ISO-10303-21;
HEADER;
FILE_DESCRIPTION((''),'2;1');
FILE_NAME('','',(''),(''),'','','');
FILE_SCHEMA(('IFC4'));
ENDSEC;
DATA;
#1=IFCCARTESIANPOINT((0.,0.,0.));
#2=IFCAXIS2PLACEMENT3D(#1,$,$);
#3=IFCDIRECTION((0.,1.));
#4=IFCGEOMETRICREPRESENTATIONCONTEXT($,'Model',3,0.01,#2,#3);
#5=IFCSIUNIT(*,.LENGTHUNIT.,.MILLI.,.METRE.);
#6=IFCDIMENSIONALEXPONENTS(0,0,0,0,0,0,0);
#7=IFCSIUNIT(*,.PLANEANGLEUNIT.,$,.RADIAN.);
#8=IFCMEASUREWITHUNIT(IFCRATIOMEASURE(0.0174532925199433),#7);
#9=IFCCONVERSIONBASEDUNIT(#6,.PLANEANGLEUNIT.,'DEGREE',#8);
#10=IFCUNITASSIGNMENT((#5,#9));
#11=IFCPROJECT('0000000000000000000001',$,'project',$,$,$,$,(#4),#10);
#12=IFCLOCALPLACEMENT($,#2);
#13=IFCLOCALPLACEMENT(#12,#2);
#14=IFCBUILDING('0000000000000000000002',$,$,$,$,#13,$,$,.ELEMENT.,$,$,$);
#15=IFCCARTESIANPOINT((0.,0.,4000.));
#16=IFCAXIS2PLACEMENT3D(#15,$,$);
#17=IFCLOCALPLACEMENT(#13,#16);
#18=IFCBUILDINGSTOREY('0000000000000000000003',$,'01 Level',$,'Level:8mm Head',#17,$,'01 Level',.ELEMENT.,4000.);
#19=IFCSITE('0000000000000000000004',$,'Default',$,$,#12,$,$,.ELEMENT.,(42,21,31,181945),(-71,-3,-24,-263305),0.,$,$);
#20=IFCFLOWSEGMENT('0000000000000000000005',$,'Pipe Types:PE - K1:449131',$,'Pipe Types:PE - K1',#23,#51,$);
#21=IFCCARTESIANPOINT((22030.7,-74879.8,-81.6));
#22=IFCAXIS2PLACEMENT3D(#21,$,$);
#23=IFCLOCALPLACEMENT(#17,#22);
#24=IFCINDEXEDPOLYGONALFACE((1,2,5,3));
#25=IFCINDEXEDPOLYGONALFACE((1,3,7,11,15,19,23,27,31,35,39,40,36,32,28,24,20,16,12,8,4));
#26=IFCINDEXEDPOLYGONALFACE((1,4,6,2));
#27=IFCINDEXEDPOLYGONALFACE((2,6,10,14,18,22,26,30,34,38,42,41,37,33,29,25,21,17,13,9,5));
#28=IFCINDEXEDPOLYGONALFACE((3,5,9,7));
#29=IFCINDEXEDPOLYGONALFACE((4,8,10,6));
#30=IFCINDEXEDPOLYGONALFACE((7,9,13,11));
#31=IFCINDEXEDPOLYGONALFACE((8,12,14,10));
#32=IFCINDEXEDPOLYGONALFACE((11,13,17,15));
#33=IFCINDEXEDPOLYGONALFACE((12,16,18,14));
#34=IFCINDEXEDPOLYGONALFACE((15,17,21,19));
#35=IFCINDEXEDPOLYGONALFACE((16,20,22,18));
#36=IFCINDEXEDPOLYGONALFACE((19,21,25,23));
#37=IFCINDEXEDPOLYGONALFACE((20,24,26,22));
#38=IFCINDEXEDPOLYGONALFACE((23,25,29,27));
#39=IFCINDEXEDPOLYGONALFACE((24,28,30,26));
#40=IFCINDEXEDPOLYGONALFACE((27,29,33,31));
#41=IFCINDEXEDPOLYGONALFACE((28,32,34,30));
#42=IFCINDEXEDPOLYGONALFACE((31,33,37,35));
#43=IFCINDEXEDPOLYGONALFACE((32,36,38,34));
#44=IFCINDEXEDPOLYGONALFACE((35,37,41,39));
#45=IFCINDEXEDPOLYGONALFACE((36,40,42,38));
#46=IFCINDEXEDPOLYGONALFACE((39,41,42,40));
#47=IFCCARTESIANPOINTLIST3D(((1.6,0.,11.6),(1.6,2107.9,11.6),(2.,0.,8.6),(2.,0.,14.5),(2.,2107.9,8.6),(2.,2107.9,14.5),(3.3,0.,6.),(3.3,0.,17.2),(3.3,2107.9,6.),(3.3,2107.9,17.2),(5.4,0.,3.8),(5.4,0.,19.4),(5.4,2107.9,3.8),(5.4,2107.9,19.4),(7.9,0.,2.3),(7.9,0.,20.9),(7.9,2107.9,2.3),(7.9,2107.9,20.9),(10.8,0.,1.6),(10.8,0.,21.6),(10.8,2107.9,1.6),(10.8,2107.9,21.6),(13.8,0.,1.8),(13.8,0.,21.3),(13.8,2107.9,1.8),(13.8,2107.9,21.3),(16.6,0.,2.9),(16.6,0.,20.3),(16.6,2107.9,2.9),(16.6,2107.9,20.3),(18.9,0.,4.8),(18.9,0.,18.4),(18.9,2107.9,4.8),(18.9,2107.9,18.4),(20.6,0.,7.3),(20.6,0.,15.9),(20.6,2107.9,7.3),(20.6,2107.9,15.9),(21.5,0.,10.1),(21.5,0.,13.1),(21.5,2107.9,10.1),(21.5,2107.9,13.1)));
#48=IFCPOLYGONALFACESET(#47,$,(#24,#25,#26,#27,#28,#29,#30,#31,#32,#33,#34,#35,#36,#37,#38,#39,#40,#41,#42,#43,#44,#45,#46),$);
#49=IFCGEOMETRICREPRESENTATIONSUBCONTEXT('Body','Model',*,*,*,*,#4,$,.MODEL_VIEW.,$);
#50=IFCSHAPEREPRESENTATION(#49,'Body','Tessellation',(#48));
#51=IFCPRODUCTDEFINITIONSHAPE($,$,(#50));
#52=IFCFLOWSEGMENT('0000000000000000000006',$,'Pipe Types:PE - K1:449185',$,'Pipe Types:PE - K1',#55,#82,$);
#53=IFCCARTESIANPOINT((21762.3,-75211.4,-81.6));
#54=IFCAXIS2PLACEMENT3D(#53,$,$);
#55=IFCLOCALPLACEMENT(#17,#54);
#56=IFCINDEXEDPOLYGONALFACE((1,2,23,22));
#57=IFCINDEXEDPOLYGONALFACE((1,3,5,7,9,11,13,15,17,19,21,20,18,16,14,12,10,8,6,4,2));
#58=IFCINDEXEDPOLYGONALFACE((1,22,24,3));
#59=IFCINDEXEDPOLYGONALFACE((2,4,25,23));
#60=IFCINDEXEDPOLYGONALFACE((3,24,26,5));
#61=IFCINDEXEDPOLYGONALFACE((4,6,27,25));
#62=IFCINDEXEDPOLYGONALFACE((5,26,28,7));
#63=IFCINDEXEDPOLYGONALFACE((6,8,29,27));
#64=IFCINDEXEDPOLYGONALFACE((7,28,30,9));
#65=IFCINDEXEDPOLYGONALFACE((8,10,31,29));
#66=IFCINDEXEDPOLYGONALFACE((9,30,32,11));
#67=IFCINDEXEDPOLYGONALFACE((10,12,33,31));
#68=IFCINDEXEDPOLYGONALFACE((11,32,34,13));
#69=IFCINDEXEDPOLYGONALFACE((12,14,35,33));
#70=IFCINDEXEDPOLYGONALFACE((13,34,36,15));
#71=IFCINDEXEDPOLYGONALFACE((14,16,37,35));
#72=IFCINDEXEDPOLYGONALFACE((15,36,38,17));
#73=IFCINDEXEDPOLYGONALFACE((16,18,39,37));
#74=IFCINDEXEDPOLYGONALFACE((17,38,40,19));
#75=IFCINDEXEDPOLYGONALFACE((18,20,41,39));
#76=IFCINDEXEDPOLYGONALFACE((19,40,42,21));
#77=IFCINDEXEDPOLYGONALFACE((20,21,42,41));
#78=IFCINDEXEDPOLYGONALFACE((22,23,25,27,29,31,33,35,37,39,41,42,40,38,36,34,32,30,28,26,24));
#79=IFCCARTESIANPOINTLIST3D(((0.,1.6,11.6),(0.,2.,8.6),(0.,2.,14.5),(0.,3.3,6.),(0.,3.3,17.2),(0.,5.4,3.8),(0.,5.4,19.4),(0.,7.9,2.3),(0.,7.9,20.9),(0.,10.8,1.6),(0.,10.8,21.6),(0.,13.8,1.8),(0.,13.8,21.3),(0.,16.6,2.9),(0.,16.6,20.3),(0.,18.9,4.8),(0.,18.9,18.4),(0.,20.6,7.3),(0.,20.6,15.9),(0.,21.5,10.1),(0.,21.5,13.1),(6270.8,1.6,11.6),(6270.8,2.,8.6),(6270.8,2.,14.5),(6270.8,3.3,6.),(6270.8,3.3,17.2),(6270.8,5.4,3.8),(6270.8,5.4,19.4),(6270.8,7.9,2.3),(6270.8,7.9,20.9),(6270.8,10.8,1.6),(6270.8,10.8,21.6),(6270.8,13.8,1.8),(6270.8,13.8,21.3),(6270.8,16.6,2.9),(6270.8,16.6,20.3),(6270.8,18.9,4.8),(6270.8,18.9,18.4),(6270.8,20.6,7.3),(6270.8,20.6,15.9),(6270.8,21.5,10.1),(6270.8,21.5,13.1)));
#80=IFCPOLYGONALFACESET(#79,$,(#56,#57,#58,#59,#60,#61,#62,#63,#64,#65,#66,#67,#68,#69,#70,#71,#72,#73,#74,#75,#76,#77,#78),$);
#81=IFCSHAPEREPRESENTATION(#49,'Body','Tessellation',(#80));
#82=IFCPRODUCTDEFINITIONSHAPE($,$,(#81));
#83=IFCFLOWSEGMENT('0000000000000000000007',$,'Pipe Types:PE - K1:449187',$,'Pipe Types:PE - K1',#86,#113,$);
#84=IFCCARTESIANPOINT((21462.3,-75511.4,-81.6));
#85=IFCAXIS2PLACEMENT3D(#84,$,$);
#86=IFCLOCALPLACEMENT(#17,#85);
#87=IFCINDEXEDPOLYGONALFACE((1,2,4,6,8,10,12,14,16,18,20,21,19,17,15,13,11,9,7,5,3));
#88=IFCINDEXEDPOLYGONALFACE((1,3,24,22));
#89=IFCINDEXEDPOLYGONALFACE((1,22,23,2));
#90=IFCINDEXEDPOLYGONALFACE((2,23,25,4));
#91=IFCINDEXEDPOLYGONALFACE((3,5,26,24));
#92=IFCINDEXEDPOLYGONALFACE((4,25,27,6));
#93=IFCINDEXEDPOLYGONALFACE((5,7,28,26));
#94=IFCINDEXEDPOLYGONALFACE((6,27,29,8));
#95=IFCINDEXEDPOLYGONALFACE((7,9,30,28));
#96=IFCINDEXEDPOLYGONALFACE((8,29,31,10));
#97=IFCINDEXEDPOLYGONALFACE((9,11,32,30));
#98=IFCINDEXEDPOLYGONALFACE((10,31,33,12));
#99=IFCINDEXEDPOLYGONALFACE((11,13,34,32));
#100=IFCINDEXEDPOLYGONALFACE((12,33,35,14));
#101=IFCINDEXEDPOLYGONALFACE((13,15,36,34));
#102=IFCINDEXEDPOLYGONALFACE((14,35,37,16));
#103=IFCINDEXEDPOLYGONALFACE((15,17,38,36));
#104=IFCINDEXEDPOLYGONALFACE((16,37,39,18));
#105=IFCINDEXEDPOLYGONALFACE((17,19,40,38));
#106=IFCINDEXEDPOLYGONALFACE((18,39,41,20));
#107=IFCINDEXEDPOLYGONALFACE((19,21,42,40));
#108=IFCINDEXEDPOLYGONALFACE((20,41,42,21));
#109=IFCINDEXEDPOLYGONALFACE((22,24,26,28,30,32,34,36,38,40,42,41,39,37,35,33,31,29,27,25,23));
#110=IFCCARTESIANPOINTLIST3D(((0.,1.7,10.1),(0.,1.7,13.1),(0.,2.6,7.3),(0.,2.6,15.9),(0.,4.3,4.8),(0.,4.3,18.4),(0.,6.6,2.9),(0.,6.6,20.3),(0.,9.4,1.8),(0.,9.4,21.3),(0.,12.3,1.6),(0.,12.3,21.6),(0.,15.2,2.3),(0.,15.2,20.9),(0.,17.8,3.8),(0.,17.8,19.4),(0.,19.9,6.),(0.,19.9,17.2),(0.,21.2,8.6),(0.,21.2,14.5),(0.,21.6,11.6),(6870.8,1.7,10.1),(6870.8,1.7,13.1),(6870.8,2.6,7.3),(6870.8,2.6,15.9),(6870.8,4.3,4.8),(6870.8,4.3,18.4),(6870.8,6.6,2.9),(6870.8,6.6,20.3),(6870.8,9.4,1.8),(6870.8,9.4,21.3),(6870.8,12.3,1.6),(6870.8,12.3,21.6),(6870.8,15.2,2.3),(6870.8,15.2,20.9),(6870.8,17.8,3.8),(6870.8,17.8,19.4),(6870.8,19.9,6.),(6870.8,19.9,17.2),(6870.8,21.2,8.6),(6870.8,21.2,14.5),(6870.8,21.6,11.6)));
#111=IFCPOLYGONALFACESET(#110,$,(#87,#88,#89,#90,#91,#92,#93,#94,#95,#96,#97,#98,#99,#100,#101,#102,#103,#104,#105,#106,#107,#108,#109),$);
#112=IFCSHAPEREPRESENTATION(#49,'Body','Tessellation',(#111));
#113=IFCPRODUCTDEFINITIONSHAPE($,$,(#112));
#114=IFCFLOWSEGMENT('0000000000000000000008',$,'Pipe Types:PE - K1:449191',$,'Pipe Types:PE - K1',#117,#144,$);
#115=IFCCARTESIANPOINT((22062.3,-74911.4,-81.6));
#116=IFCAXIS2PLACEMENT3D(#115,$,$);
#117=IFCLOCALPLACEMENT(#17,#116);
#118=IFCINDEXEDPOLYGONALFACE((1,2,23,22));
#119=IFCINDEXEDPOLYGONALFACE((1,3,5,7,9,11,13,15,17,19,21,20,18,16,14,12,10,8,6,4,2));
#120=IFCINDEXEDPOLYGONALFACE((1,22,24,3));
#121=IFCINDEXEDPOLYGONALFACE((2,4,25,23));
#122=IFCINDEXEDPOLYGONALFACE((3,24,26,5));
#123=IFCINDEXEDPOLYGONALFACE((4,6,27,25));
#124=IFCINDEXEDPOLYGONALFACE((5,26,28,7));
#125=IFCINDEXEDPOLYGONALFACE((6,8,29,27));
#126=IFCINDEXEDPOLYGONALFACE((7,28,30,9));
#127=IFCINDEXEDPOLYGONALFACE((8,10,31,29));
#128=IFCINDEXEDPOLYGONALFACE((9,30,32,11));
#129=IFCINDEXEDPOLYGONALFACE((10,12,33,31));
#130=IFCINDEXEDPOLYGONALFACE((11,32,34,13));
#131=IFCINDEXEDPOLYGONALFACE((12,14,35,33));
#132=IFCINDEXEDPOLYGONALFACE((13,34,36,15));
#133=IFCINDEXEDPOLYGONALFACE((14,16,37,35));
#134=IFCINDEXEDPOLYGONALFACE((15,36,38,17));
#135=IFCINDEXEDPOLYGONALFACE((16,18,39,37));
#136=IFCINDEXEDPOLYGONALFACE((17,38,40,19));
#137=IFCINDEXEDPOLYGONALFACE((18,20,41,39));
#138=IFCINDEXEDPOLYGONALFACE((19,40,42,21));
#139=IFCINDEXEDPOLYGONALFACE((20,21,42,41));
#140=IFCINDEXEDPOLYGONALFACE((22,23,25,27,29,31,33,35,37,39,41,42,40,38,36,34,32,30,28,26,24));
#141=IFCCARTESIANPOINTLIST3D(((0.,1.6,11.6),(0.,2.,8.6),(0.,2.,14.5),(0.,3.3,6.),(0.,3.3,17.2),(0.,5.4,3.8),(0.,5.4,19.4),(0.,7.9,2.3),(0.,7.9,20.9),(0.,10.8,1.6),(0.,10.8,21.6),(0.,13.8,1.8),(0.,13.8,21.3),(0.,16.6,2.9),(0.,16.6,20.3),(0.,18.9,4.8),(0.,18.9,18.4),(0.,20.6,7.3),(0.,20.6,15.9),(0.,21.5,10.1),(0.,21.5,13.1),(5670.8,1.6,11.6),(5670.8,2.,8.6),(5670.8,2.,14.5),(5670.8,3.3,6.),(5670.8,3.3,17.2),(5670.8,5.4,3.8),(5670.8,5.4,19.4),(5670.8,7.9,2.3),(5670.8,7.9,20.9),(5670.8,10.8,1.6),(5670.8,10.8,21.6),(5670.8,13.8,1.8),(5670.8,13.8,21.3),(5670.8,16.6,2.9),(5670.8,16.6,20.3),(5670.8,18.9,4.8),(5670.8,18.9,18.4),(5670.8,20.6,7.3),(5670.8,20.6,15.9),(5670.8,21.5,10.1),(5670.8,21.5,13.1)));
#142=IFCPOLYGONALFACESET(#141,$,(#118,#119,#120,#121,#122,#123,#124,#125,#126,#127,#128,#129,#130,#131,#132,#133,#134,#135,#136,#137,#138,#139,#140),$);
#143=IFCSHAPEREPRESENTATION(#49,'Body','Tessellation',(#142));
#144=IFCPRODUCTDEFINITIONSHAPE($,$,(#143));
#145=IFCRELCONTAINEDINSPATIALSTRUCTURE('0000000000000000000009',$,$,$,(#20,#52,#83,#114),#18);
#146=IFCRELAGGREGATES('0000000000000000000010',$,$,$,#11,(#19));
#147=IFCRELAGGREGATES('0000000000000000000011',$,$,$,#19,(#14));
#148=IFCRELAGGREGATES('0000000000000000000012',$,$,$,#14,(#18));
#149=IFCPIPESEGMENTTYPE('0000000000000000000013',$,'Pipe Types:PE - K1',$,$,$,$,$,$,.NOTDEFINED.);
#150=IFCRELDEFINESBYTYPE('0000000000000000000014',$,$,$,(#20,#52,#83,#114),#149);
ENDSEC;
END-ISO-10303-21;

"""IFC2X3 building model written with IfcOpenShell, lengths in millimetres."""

from ifc_helpers import new_model, entity, si_unit, converted_unit, direction, frame, frame_2d, origin, origin_2d_with_axis, place, context, subcontext, project, spatial, circle, extrude, type_object, element, save


model = new_model("IFC2X3")

# Units and contexts
model_context = context("Model", 3, precision=0.01, world=origin(), true_north=direction((0.0, 1.0)))
body_context = subcontext(model_context, "Body", "Model", "MODEL_VIEW")
ifc_project = project(units=[si_unit("LENGTHUNIT", "METRE", prefix="MILLI"), converted_unit("PLANEANGLEUNIT", "DEGREE", entity("IfcRatioMeasure", 0.0174532925199433), si_unit("PLANEANGLEUNIT", "RADIAN"), dimensions=[0, 0, 0, 0, 0, 0, 0])], contexts=[model_context])

# Site, building, storey
site_placement = place(None, origin())
site = spatial("IfcSite", under=ifc_project, at=site_placement, Name="Default", CompositionType="ELEMENT", RefLatitude=(42, 21, 31, 181945), RefLongitude=(-71, -3, -24, -263305), RefElevation=0.0)
building_placement = place(site_placement, origin())
building = spatial("IfcBuilding", under=site, at=building_placement, CompositionType="ELEMENT")
storey_placement = place(building_placement, frame((0.0, 0.0, 4000.0)))
storey = spatial("IfcBuildingStorey", under=building, at=storey_placement, Name="01 Level", ObjectType="Level:8mm Head", LongName="01 Level", CompositionType="ELEMENT", Elevation=4000.0)

# Flow segments
pipe_segment_type = type_object("IfcPipeSegmentType", Name="Pipe Types:PE - K1", PredefinedType="NOTDEFINED")
flow_segment_1_placement = place(storey_placement, frame((22030.7, -74879.8, -81.6)))
element("IfcFlowSegment", 1, at=flow_segment_1_placement, inside=storey, type_object=pipe_segment_type, Name="Pipe Types:PE - K1:449131", ObjectType="Pipe Types:PE - K1", context=body_context, shape_type="SweptSolid", body=[
    extrude(circle(Radius=10.0, at=frame_2d((0.0, 0.0), x_axis=(1.0, 0.0))), frame((11.6, 0.0, 11.6), z_axis=(0.0, 1.0, 0.0), x_axis=(-1.0, 0.0, 0.0)), (0.0, 0.0, 1.0), 2107.9),
])
flow_segment_2_placement = place(storey_placement, frame((21762.3, -75211.4, -81.6)))
element("IfcFlowSegment", 2, at=flow_segment_2_placement, inside=storey, type_object=pipe_segment_type, Name="Pipe Types:PE - K1:449185", ObjectType="Pipe Types:PE - K1", context=body_context, shape_type="SweptSolid", body=[
    extrude(circle(Radius=10.0, at=origin_2d_with_axis()), frame((0.0, 11.6, 11.6), z_axis=(1.0, 0.0, 0.0), x_axis=(0.0, -1.0, 0.0)), (0.0, 0.0, 1.0), 6270.8),
])
flow_segment_3_placement = place(storey_placement, frame((21462.3, -75511.4, -81.6)))
element("IfcFlowSegment", 3, at=flow_segment_3_placement, inside=storey, type_object=pipe_segment_type, Name="Pipe Types:PE - K1:449187", ObjectType="Pipe Types:PE - K1", context=body_context, shape_type="SweptSolid", body=[
    extrude(circle(Radius=10.0, at=frame_2d((0.0, 0.0), x_axis=(1.0, 0.0))), frame((0.0, 11.6, 11.6), z_axis=(1.0, 0.0, 0.0), x_axis=(0.0, 1.0, 0.0)), (0.0, 0.0, 1.0), 6870.8),
])
flow_segment_4_placement = place(storey_placement, frame((22062.3, -74911.4, -81.6)))
element("IfcFlowSegment", 4, at=flow_segment_4_placement, inside=storey, type_object=pipe_segment_type, Name="Pipe Types:PE - K1:449191", ObjectType="Pipe Types:PE - K1", context=body_context, shape_type="SweptSolid", body=[
    extrude(circle(Radius=10.0, at=origin_2d_with_axis()), frame((0.0, 11.6, 11.6), z_axis=(1.0, 0.0, 0.0), x_axis=(0.0, -1.0, 0.0)), (0.0, 0.0, 1.0), 5670.8),
])

save(model, "model.ifc")
